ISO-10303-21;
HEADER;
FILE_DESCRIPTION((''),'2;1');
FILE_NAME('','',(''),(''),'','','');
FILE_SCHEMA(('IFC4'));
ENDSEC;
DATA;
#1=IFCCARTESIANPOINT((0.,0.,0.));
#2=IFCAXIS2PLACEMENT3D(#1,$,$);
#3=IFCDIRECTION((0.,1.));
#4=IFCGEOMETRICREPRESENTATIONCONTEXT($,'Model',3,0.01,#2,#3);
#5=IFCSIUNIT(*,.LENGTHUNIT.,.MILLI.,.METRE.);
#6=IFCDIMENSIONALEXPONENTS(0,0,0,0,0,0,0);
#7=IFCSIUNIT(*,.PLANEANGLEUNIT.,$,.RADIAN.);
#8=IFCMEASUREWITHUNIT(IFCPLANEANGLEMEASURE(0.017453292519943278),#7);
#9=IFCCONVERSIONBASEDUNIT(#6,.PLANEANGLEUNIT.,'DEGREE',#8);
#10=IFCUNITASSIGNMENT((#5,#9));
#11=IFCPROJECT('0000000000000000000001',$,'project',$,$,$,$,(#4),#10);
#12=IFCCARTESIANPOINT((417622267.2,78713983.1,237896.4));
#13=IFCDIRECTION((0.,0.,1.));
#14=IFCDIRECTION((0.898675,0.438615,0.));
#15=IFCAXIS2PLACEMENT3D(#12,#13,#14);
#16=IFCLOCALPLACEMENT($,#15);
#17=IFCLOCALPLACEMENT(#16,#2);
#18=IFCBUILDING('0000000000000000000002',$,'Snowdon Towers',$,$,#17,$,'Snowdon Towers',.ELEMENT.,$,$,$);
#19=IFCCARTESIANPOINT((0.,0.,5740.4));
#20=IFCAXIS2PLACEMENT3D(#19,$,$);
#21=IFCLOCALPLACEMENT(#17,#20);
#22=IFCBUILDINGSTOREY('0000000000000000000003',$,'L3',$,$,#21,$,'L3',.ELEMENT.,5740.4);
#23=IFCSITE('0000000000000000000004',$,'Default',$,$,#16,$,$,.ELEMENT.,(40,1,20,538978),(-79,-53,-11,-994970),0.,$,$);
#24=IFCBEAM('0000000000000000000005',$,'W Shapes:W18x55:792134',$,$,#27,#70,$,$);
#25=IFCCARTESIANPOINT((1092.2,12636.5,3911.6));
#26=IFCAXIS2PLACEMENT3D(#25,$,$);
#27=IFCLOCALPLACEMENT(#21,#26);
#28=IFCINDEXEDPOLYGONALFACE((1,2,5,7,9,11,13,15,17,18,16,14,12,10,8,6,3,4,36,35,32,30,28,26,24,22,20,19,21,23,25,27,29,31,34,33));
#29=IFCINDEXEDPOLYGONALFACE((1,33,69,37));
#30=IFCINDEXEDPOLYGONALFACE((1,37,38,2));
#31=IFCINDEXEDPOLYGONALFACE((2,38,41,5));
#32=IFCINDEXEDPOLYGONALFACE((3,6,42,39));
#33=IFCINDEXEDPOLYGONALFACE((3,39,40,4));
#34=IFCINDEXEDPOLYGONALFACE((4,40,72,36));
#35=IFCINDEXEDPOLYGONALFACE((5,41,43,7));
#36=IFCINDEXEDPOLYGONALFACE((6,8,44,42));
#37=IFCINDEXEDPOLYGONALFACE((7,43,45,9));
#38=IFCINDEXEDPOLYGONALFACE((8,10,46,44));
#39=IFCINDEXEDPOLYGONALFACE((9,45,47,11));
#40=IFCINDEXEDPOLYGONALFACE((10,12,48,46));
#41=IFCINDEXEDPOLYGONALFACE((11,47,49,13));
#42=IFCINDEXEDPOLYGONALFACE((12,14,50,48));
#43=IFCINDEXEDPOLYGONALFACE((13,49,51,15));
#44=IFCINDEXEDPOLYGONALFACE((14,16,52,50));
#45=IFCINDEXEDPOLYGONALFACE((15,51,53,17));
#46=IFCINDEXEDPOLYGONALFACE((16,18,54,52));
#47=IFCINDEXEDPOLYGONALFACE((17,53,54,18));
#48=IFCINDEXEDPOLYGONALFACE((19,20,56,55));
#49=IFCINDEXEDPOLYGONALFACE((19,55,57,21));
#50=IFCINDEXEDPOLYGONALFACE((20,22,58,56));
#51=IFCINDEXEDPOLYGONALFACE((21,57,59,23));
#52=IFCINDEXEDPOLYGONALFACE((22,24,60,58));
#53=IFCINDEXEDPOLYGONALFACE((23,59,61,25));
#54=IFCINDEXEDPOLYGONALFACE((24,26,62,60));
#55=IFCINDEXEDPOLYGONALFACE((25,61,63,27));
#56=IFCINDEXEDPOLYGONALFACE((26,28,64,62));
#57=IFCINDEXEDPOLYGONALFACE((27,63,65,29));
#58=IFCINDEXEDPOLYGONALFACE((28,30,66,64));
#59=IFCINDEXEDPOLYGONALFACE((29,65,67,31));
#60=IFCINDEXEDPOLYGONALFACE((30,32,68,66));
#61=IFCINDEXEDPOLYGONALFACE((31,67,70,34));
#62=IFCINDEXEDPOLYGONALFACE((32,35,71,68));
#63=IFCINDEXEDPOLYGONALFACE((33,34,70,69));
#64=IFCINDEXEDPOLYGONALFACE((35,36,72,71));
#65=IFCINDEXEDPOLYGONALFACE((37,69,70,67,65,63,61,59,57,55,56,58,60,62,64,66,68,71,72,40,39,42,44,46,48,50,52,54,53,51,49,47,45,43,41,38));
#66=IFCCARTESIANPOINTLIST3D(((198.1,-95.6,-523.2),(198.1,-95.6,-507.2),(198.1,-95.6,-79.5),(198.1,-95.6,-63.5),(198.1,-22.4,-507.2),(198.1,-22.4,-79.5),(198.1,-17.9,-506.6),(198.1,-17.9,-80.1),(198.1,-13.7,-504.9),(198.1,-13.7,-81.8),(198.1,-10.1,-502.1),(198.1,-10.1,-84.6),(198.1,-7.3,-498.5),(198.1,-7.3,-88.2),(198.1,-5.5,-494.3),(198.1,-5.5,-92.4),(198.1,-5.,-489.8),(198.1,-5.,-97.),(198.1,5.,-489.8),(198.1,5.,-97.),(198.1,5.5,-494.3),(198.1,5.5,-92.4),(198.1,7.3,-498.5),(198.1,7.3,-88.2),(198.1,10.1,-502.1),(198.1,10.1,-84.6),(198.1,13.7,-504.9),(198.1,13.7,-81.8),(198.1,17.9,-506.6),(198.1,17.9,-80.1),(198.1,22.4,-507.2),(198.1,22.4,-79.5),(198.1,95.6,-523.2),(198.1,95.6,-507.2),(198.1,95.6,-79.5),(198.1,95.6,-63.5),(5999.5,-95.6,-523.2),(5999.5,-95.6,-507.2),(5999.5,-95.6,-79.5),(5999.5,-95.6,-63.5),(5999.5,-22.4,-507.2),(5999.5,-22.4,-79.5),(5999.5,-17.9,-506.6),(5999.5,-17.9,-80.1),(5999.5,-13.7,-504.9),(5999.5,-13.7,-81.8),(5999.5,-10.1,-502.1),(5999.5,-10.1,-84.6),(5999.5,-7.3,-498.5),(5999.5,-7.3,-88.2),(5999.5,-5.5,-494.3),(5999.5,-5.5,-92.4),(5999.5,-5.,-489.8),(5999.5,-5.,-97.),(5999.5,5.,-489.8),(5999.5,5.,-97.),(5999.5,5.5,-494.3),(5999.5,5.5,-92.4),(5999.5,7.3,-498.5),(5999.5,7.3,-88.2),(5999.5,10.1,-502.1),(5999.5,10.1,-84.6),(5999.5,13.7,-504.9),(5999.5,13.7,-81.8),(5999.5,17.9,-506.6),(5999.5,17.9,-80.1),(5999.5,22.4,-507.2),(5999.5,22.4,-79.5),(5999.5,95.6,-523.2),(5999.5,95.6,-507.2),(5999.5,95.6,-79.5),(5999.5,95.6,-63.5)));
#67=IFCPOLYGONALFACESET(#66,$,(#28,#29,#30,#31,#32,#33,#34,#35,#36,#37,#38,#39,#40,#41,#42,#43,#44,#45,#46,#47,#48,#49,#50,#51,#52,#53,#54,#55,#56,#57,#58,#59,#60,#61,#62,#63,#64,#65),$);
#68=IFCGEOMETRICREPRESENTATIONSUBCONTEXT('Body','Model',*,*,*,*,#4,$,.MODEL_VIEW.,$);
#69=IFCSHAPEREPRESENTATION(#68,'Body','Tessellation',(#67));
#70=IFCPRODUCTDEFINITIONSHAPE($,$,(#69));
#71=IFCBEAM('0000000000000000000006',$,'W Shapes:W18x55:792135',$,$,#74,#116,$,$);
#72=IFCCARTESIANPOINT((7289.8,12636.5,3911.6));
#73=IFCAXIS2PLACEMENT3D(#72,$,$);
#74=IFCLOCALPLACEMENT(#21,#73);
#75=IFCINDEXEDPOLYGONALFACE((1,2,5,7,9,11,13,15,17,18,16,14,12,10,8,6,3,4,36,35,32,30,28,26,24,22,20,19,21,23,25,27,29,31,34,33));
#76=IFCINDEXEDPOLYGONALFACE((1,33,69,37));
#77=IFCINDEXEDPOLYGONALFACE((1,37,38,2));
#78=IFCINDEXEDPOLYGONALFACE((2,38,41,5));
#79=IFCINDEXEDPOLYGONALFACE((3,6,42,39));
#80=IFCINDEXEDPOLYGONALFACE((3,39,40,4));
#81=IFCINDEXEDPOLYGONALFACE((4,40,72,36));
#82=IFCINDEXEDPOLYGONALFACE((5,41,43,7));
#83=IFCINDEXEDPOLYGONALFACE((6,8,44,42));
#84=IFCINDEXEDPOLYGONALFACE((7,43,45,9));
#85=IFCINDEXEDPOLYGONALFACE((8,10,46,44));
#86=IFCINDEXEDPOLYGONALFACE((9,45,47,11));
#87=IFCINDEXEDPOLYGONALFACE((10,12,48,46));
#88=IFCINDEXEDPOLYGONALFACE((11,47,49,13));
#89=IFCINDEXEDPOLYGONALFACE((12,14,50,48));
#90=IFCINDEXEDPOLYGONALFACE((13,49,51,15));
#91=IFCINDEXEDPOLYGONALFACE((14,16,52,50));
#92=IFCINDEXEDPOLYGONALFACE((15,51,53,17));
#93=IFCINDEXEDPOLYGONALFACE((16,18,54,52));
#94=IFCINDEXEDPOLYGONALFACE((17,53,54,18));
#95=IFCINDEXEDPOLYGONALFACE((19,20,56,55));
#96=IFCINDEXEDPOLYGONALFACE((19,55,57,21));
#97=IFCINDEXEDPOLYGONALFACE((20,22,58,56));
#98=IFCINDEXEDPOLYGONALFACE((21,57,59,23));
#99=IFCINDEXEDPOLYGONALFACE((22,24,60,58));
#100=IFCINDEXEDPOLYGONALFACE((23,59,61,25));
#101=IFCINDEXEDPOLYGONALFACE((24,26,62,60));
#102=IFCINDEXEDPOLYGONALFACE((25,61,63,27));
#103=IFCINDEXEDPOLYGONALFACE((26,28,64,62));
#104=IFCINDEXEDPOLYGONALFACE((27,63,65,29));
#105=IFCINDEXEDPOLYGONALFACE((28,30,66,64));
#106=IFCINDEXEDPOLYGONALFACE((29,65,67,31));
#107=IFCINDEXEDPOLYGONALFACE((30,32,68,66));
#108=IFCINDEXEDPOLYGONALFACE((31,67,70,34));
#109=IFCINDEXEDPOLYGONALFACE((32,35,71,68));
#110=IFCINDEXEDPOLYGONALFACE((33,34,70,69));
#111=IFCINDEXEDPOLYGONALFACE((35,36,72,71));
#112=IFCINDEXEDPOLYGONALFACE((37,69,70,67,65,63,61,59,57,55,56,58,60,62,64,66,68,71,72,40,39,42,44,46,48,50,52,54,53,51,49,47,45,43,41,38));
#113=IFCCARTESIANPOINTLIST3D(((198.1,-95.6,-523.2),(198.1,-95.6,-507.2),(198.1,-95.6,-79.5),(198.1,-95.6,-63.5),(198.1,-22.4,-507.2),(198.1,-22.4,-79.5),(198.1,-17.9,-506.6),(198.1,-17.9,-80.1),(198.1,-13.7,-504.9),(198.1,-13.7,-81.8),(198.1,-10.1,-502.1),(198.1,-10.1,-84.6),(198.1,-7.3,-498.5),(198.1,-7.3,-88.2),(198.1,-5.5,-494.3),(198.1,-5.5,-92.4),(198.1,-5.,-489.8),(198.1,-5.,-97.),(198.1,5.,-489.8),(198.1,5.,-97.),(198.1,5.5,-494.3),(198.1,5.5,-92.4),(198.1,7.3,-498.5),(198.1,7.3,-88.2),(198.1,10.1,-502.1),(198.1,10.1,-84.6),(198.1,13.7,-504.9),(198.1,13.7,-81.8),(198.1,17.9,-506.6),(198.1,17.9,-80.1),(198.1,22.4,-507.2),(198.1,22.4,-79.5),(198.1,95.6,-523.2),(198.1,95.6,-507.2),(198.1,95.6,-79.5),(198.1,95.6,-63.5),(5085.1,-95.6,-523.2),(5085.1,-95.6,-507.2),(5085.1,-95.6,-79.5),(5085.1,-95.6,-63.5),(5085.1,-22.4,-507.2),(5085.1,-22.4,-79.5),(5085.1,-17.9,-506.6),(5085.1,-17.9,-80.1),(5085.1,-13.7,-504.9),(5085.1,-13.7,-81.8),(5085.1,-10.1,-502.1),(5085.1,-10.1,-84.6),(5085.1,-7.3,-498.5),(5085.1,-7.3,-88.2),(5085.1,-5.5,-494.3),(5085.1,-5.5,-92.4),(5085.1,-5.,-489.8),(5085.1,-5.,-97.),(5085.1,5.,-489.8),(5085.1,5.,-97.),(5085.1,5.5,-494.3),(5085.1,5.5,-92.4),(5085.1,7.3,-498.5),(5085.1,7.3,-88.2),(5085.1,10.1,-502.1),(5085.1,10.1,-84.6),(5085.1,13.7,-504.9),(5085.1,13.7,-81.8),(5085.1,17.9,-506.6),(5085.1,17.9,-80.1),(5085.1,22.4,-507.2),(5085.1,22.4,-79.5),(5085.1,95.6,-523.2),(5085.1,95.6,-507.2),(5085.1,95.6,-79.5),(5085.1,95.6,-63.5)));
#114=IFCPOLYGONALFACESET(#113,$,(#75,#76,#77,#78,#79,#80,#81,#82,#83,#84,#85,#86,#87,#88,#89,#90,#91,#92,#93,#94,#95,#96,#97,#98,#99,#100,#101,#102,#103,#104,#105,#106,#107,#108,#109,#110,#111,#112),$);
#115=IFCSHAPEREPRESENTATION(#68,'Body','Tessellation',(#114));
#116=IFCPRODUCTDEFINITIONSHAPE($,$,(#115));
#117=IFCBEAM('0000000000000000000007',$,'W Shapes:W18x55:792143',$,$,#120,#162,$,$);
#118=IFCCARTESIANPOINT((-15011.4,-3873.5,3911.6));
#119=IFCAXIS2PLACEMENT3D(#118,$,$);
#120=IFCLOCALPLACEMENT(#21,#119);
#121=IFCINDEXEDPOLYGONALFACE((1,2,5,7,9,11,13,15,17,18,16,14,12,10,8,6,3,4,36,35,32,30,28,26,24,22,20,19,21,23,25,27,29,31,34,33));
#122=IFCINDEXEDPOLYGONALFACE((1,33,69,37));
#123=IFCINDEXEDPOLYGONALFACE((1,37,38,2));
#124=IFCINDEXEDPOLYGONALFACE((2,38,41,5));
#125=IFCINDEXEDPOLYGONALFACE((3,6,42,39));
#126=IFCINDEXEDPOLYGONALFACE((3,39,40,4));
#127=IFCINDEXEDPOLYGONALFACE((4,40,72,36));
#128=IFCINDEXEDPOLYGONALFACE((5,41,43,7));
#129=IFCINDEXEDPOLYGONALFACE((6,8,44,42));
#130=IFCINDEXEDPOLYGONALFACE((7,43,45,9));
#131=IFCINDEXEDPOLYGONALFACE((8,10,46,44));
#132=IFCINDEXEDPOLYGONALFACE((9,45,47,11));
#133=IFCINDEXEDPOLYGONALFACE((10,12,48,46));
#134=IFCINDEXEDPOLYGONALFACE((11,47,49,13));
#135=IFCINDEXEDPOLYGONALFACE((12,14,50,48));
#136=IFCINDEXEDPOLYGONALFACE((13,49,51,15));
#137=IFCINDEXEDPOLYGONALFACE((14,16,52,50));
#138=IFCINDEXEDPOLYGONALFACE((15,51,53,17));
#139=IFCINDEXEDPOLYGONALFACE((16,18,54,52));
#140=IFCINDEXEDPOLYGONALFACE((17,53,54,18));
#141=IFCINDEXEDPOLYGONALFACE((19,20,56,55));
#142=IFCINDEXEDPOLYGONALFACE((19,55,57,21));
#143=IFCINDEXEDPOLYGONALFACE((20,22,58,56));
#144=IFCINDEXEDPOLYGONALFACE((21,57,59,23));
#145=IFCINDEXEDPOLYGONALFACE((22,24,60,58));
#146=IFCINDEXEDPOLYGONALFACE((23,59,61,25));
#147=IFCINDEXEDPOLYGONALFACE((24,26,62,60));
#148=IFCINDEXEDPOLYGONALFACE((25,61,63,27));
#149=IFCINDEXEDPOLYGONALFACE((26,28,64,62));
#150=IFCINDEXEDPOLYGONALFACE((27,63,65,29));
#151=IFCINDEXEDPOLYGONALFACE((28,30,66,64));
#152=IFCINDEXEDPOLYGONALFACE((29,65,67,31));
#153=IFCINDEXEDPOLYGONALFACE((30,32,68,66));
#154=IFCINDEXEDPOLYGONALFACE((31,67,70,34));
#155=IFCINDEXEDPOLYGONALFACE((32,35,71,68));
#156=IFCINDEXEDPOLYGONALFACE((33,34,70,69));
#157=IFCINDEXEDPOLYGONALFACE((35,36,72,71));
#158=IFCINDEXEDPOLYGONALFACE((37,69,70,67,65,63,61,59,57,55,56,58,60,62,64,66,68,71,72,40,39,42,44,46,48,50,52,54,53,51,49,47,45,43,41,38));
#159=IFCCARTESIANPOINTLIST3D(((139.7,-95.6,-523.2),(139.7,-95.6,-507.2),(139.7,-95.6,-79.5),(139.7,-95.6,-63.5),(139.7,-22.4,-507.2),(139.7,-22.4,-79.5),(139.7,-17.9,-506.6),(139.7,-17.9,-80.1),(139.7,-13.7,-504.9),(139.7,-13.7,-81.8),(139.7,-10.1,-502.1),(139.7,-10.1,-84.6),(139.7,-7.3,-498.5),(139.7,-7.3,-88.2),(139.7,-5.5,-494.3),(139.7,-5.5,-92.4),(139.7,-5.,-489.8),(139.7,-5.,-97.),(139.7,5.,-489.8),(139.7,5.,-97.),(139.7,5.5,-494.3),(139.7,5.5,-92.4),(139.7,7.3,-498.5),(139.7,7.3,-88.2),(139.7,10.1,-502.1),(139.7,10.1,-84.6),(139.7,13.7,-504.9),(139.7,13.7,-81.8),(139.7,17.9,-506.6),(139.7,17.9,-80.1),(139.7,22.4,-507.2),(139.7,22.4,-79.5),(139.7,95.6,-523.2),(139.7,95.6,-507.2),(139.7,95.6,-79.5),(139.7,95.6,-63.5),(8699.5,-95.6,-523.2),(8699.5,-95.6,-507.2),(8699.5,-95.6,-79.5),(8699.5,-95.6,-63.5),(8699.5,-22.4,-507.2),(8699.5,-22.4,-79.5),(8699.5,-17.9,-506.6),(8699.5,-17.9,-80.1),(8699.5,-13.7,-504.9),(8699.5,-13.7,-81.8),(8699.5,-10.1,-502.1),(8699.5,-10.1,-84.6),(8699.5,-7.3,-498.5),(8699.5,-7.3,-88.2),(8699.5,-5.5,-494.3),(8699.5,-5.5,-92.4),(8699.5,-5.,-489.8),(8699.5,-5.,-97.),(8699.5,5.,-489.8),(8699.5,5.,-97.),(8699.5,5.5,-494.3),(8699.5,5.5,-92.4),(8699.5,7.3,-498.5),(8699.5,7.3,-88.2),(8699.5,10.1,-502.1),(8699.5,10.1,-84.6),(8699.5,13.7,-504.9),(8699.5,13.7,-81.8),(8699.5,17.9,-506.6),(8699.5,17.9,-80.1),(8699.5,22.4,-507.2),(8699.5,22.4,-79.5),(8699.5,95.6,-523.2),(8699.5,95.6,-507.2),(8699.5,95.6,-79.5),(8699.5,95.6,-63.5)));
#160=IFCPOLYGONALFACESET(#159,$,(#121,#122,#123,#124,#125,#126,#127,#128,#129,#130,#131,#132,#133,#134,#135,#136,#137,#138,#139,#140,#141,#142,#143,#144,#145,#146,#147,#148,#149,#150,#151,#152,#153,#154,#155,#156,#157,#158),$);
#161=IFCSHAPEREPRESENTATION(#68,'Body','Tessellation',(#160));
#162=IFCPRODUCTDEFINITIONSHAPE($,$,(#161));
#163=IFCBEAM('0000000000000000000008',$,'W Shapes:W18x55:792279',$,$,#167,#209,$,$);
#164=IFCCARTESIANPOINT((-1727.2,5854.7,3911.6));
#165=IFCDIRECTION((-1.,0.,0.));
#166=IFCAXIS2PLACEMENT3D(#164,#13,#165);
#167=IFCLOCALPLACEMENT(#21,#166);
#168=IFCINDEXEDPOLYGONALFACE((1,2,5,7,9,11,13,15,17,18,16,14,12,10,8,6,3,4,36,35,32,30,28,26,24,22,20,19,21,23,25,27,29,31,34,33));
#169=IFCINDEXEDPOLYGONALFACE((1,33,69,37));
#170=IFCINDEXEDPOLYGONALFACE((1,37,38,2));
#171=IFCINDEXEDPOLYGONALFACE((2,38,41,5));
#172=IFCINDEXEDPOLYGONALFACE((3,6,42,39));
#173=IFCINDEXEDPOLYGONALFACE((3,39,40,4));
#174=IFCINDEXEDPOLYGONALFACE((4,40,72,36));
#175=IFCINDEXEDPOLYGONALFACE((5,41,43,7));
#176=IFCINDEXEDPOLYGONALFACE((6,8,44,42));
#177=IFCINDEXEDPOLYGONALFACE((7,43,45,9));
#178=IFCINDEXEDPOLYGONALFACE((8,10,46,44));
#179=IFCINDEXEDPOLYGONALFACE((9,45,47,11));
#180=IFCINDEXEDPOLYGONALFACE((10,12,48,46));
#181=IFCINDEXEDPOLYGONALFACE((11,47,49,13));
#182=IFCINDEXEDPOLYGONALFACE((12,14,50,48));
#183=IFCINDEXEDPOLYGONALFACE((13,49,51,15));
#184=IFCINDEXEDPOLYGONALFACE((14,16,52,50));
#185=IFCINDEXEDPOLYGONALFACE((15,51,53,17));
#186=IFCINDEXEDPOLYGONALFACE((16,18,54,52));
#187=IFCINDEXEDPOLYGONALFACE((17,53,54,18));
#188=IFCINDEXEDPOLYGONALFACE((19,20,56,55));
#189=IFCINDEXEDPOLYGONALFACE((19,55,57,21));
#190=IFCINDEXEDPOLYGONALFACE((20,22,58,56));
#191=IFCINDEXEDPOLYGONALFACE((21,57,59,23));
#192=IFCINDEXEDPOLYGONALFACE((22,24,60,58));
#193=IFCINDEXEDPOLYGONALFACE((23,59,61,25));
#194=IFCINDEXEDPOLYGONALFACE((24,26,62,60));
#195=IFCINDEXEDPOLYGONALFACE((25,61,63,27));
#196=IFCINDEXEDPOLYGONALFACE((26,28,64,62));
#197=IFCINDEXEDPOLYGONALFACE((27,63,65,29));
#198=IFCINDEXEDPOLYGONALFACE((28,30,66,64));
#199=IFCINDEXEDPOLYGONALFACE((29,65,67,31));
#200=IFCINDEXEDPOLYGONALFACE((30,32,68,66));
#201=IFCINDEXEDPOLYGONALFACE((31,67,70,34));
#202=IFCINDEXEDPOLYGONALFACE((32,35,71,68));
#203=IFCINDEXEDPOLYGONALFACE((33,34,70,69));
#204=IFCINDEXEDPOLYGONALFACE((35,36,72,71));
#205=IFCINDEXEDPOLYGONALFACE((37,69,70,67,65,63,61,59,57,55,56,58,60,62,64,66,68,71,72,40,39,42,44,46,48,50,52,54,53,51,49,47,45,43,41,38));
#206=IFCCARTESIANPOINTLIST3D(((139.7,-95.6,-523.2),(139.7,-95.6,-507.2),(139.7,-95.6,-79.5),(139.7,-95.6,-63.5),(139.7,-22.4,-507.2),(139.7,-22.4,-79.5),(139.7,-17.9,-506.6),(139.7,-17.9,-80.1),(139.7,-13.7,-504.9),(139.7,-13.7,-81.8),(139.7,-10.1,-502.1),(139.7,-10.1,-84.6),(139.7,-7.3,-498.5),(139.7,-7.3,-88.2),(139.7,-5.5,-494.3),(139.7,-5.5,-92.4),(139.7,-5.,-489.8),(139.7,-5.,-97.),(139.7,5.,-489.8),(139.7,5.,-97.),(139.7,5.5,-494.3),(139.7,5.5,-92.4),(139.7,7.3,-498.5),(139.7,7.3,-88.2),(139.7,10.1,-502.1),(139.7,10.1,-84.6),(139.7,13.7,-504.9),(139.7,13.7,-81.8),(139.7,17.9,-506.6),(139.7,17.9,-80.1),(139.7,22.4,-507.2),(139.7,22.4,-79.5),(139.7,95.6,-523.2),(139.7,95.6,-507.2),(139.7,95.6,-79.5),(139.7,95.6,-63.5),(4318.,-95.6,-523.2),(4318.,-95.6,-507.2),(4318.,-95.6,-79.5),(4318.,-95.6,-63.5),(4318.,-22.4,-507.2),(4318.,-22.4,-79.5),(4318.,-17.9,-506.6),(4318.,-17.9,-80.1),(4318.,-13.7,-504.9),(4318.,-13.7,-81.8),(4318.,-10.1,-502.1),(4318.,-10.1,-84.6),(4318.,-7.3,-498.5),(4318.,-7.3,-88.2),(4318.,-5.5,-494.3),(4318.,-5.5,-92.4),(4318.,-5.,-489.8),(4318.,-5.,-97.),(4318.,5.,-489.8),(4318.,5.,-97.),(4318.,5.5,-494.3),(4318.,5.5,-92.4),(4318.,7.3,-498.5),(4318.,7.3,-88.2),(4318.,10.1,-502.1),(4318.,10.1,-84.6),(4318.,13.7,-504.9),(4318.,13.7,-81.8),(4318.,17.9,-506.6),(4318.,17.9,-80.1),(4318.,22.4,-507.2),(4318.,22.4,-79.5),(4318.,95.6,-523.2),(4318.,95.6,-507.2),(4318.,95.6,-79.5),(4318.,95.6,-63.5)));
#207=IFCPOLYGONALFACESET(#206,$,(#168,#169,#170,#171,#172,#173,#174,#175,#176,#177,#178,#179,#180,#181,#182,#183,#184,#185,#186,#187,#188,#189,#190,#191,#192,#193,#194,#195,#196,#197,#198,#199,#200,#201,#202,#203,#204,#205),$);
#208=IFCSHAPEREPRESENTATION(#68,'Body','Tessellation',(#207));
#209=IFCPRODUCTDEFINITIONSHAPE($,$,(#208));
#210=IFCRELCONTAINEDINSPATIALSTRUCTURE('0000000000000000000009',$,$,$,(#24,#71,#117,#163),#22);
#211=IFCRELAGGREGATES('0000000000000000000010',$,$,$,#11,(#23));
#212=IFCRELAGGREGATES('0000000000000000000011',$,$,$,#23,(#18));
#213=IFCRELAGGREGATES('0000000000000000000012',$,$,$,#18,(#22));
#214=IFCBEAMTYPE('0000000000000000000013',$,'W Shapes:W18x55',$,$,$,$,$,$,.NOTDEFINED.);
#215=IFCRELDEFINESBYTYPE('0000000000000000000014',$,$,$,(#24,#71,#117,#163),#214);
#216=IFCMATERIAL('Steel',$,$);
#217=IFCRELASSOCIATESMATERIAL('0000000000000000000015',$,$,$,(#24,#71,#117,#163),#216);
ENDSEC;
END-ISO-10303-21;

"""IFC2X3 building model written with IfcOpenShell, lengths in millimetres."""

from ifc_helpers import new_model, entity, si_unit, converted_unit, direction, frame, frame_2d, origin, place, context, subcontext, project, spatial, i_section, extrude, material, type_object, element, save


model = new_model("IFC2X3")

# Units and contexts
model_context = context("Model", 3, precision=0.01, world=origin(), true_north=direction((0.0, 1.0)))
body_context = subcontext(model_context, "Body", "Model", "MODEL_VIEW")
ifc_project = project(units=[si_unit("LENGTHUNIT", "METRE", prefix="MILLI"), converted_unit("PLANEANGLEUNIT", "DEGREE", entity("IfcPlaneAngleMeasure", 0.017453292519943278), si_unit("PLANEANGLEUNIT", "RADIAN"), dimensions=[0, 0, 0, 0, 0, 0, 0])], contexts=[model_context])

# Site, building, storey
site_placement = place(None, frame((417622267.2, 78713983.1, 237896.4), z_axis=(0.0, 0.0, 1.0), x_axis=(0.898675, 0.438615, 0.0)))
site = spatial("IfcSite", under=ifc_project, at=site_placement, Name="Default", CompositionType="ELEMENT", RefLatitude=(40, 1, 20, 538978), RefLongitude=(-79, -53, -11, -994970), RefElevation=0.0)
building_placement = place(site_placement, origin())
building = spatial("IfcBuilding", under=site, at=building_placement, Name="Snowdon Towers", LongName="Snowdon Towers", CompositionType="ELEMENT")
storey_placement = place(building_placement, frame((0.0, 0.0, 5740.4)))
storey = spatial("IfcBuildingStorey", under=building, at=storey_placement, Name="L3", LongName="L3", CompositionType="ELEMENT", Elevation=5740.4)

# Shared definitions
ifc_material_1 = material(Name="Steel")

# Beams
beam_type = type_object("IfcBeamType", Name="W Shapes:W18x55", PredefinedType="NOTDEFINED")
beam_1_placement = place(storey_placement, frame((1092.2, 12636.5, 3911.6)))
element("IfcBeam", 1, at=beam_1_placement, inside=storey, type_object=beam_type, material=ifc_material_1, Name="W Shapes:W18x55:792134", context=body_context, shape_type="SweptSolid", body=[
    extrude(i_section(OverallWidth=191.3, OverallDepth=459.7, WebThickness=9.9, FlangeThickness=16.0, FilletRadius=17.5, at=frame_2d((0.0, 0.0), x_axis=(0.0, 1.0))), frame((198.1, 0.0, -293.4), z_axis=(1.0, 0.0, 0.0), x_axis=(0.0, 0.0, -1.0)), (0.0, 0.0, 1.0), 5801.4),
])
beam_2_placement = place(storey_placement, frame((7289.8, 12636.5, 3911.6)))
element("IfcBeam", 2, at=beam_2_placement, inside=storey, type_object=beam_type, material=ifc_material_1, Name="W Shapes:W18x55:792135", context=body_context, shape_type="SweptSolid", body=[
    extrude(i_section(OverallWidth=191.3, OverallDepth=459.7, WebThickness=9.9, FlangeThickness=16.0, FilletRadius=17.5, at=frame_2d((0.0, 0.0), x_axis=(0.0, 1.0))), frame((198.1, 0.0, -293.4), z_axis=(1.0, 0.0, 0.0), x_axis=(0.0, 0.0, -1.0)), (0.0, 0.0, 1.0), 4887.0),
])
beam_3_placement = place(storey_placement, frame((-15011.4, -3873.5, 3911.6)))
element("IfcBeam", 3, at=beam_3_placement, inside=storey, type_object=beam_type, material=ifc_material_1, Name="W Shapes:W18x55:792143", context=body_context, shape_type="SweptSolid", body=[
    extrude(i_section(OverallWidth=191.3, OverallDepth=459.7, WebThickness=9.9, FlangeThickness=16.0, FilletRadius=17.5, at=frame_2d((0.0, 0.0), x_axis=(0.0, 1.0))), frame((139.7, 0.0, -293.4), z_axis=(1.0, 0.0, 0.0), x_axis=(0.0, 0.0, -1.0)), (0.0, 0.0, 1.0), 8559.8),
])
beam_4_placement = place(storey_placement, frame((-1727.2, 5854.7, 3911.6), z_axis=(0.0, 0.0, 1.0), x_axis=(-1.0, 0.0, 0.0)))
element("IfcBeam", 4, at=beam_4_placement, inside=storey, type_object=beam_type, material=ifc_material_1, Name="W Shapes:W18x55:792279", context=body_context, shape_type="SweptSolid", body=[
    extrude(i_section(OverallWidth=191.3, OverallDepth=459.7, WebThickness=9.9, FlangeThickness=16.0, FilletRadius=17.5, at=frame_2d((0.0, 0.0), x_axis=(0.0, 1.0))), frame((139.7, 0.0, -293.4), z_axis=(1.0, 0.0, 0.0), x_axis=(0.0, 0.0, -1.0)), (0.0, 0.0, 1.0), 4178.3),
])

save(model, "model.ifc")
